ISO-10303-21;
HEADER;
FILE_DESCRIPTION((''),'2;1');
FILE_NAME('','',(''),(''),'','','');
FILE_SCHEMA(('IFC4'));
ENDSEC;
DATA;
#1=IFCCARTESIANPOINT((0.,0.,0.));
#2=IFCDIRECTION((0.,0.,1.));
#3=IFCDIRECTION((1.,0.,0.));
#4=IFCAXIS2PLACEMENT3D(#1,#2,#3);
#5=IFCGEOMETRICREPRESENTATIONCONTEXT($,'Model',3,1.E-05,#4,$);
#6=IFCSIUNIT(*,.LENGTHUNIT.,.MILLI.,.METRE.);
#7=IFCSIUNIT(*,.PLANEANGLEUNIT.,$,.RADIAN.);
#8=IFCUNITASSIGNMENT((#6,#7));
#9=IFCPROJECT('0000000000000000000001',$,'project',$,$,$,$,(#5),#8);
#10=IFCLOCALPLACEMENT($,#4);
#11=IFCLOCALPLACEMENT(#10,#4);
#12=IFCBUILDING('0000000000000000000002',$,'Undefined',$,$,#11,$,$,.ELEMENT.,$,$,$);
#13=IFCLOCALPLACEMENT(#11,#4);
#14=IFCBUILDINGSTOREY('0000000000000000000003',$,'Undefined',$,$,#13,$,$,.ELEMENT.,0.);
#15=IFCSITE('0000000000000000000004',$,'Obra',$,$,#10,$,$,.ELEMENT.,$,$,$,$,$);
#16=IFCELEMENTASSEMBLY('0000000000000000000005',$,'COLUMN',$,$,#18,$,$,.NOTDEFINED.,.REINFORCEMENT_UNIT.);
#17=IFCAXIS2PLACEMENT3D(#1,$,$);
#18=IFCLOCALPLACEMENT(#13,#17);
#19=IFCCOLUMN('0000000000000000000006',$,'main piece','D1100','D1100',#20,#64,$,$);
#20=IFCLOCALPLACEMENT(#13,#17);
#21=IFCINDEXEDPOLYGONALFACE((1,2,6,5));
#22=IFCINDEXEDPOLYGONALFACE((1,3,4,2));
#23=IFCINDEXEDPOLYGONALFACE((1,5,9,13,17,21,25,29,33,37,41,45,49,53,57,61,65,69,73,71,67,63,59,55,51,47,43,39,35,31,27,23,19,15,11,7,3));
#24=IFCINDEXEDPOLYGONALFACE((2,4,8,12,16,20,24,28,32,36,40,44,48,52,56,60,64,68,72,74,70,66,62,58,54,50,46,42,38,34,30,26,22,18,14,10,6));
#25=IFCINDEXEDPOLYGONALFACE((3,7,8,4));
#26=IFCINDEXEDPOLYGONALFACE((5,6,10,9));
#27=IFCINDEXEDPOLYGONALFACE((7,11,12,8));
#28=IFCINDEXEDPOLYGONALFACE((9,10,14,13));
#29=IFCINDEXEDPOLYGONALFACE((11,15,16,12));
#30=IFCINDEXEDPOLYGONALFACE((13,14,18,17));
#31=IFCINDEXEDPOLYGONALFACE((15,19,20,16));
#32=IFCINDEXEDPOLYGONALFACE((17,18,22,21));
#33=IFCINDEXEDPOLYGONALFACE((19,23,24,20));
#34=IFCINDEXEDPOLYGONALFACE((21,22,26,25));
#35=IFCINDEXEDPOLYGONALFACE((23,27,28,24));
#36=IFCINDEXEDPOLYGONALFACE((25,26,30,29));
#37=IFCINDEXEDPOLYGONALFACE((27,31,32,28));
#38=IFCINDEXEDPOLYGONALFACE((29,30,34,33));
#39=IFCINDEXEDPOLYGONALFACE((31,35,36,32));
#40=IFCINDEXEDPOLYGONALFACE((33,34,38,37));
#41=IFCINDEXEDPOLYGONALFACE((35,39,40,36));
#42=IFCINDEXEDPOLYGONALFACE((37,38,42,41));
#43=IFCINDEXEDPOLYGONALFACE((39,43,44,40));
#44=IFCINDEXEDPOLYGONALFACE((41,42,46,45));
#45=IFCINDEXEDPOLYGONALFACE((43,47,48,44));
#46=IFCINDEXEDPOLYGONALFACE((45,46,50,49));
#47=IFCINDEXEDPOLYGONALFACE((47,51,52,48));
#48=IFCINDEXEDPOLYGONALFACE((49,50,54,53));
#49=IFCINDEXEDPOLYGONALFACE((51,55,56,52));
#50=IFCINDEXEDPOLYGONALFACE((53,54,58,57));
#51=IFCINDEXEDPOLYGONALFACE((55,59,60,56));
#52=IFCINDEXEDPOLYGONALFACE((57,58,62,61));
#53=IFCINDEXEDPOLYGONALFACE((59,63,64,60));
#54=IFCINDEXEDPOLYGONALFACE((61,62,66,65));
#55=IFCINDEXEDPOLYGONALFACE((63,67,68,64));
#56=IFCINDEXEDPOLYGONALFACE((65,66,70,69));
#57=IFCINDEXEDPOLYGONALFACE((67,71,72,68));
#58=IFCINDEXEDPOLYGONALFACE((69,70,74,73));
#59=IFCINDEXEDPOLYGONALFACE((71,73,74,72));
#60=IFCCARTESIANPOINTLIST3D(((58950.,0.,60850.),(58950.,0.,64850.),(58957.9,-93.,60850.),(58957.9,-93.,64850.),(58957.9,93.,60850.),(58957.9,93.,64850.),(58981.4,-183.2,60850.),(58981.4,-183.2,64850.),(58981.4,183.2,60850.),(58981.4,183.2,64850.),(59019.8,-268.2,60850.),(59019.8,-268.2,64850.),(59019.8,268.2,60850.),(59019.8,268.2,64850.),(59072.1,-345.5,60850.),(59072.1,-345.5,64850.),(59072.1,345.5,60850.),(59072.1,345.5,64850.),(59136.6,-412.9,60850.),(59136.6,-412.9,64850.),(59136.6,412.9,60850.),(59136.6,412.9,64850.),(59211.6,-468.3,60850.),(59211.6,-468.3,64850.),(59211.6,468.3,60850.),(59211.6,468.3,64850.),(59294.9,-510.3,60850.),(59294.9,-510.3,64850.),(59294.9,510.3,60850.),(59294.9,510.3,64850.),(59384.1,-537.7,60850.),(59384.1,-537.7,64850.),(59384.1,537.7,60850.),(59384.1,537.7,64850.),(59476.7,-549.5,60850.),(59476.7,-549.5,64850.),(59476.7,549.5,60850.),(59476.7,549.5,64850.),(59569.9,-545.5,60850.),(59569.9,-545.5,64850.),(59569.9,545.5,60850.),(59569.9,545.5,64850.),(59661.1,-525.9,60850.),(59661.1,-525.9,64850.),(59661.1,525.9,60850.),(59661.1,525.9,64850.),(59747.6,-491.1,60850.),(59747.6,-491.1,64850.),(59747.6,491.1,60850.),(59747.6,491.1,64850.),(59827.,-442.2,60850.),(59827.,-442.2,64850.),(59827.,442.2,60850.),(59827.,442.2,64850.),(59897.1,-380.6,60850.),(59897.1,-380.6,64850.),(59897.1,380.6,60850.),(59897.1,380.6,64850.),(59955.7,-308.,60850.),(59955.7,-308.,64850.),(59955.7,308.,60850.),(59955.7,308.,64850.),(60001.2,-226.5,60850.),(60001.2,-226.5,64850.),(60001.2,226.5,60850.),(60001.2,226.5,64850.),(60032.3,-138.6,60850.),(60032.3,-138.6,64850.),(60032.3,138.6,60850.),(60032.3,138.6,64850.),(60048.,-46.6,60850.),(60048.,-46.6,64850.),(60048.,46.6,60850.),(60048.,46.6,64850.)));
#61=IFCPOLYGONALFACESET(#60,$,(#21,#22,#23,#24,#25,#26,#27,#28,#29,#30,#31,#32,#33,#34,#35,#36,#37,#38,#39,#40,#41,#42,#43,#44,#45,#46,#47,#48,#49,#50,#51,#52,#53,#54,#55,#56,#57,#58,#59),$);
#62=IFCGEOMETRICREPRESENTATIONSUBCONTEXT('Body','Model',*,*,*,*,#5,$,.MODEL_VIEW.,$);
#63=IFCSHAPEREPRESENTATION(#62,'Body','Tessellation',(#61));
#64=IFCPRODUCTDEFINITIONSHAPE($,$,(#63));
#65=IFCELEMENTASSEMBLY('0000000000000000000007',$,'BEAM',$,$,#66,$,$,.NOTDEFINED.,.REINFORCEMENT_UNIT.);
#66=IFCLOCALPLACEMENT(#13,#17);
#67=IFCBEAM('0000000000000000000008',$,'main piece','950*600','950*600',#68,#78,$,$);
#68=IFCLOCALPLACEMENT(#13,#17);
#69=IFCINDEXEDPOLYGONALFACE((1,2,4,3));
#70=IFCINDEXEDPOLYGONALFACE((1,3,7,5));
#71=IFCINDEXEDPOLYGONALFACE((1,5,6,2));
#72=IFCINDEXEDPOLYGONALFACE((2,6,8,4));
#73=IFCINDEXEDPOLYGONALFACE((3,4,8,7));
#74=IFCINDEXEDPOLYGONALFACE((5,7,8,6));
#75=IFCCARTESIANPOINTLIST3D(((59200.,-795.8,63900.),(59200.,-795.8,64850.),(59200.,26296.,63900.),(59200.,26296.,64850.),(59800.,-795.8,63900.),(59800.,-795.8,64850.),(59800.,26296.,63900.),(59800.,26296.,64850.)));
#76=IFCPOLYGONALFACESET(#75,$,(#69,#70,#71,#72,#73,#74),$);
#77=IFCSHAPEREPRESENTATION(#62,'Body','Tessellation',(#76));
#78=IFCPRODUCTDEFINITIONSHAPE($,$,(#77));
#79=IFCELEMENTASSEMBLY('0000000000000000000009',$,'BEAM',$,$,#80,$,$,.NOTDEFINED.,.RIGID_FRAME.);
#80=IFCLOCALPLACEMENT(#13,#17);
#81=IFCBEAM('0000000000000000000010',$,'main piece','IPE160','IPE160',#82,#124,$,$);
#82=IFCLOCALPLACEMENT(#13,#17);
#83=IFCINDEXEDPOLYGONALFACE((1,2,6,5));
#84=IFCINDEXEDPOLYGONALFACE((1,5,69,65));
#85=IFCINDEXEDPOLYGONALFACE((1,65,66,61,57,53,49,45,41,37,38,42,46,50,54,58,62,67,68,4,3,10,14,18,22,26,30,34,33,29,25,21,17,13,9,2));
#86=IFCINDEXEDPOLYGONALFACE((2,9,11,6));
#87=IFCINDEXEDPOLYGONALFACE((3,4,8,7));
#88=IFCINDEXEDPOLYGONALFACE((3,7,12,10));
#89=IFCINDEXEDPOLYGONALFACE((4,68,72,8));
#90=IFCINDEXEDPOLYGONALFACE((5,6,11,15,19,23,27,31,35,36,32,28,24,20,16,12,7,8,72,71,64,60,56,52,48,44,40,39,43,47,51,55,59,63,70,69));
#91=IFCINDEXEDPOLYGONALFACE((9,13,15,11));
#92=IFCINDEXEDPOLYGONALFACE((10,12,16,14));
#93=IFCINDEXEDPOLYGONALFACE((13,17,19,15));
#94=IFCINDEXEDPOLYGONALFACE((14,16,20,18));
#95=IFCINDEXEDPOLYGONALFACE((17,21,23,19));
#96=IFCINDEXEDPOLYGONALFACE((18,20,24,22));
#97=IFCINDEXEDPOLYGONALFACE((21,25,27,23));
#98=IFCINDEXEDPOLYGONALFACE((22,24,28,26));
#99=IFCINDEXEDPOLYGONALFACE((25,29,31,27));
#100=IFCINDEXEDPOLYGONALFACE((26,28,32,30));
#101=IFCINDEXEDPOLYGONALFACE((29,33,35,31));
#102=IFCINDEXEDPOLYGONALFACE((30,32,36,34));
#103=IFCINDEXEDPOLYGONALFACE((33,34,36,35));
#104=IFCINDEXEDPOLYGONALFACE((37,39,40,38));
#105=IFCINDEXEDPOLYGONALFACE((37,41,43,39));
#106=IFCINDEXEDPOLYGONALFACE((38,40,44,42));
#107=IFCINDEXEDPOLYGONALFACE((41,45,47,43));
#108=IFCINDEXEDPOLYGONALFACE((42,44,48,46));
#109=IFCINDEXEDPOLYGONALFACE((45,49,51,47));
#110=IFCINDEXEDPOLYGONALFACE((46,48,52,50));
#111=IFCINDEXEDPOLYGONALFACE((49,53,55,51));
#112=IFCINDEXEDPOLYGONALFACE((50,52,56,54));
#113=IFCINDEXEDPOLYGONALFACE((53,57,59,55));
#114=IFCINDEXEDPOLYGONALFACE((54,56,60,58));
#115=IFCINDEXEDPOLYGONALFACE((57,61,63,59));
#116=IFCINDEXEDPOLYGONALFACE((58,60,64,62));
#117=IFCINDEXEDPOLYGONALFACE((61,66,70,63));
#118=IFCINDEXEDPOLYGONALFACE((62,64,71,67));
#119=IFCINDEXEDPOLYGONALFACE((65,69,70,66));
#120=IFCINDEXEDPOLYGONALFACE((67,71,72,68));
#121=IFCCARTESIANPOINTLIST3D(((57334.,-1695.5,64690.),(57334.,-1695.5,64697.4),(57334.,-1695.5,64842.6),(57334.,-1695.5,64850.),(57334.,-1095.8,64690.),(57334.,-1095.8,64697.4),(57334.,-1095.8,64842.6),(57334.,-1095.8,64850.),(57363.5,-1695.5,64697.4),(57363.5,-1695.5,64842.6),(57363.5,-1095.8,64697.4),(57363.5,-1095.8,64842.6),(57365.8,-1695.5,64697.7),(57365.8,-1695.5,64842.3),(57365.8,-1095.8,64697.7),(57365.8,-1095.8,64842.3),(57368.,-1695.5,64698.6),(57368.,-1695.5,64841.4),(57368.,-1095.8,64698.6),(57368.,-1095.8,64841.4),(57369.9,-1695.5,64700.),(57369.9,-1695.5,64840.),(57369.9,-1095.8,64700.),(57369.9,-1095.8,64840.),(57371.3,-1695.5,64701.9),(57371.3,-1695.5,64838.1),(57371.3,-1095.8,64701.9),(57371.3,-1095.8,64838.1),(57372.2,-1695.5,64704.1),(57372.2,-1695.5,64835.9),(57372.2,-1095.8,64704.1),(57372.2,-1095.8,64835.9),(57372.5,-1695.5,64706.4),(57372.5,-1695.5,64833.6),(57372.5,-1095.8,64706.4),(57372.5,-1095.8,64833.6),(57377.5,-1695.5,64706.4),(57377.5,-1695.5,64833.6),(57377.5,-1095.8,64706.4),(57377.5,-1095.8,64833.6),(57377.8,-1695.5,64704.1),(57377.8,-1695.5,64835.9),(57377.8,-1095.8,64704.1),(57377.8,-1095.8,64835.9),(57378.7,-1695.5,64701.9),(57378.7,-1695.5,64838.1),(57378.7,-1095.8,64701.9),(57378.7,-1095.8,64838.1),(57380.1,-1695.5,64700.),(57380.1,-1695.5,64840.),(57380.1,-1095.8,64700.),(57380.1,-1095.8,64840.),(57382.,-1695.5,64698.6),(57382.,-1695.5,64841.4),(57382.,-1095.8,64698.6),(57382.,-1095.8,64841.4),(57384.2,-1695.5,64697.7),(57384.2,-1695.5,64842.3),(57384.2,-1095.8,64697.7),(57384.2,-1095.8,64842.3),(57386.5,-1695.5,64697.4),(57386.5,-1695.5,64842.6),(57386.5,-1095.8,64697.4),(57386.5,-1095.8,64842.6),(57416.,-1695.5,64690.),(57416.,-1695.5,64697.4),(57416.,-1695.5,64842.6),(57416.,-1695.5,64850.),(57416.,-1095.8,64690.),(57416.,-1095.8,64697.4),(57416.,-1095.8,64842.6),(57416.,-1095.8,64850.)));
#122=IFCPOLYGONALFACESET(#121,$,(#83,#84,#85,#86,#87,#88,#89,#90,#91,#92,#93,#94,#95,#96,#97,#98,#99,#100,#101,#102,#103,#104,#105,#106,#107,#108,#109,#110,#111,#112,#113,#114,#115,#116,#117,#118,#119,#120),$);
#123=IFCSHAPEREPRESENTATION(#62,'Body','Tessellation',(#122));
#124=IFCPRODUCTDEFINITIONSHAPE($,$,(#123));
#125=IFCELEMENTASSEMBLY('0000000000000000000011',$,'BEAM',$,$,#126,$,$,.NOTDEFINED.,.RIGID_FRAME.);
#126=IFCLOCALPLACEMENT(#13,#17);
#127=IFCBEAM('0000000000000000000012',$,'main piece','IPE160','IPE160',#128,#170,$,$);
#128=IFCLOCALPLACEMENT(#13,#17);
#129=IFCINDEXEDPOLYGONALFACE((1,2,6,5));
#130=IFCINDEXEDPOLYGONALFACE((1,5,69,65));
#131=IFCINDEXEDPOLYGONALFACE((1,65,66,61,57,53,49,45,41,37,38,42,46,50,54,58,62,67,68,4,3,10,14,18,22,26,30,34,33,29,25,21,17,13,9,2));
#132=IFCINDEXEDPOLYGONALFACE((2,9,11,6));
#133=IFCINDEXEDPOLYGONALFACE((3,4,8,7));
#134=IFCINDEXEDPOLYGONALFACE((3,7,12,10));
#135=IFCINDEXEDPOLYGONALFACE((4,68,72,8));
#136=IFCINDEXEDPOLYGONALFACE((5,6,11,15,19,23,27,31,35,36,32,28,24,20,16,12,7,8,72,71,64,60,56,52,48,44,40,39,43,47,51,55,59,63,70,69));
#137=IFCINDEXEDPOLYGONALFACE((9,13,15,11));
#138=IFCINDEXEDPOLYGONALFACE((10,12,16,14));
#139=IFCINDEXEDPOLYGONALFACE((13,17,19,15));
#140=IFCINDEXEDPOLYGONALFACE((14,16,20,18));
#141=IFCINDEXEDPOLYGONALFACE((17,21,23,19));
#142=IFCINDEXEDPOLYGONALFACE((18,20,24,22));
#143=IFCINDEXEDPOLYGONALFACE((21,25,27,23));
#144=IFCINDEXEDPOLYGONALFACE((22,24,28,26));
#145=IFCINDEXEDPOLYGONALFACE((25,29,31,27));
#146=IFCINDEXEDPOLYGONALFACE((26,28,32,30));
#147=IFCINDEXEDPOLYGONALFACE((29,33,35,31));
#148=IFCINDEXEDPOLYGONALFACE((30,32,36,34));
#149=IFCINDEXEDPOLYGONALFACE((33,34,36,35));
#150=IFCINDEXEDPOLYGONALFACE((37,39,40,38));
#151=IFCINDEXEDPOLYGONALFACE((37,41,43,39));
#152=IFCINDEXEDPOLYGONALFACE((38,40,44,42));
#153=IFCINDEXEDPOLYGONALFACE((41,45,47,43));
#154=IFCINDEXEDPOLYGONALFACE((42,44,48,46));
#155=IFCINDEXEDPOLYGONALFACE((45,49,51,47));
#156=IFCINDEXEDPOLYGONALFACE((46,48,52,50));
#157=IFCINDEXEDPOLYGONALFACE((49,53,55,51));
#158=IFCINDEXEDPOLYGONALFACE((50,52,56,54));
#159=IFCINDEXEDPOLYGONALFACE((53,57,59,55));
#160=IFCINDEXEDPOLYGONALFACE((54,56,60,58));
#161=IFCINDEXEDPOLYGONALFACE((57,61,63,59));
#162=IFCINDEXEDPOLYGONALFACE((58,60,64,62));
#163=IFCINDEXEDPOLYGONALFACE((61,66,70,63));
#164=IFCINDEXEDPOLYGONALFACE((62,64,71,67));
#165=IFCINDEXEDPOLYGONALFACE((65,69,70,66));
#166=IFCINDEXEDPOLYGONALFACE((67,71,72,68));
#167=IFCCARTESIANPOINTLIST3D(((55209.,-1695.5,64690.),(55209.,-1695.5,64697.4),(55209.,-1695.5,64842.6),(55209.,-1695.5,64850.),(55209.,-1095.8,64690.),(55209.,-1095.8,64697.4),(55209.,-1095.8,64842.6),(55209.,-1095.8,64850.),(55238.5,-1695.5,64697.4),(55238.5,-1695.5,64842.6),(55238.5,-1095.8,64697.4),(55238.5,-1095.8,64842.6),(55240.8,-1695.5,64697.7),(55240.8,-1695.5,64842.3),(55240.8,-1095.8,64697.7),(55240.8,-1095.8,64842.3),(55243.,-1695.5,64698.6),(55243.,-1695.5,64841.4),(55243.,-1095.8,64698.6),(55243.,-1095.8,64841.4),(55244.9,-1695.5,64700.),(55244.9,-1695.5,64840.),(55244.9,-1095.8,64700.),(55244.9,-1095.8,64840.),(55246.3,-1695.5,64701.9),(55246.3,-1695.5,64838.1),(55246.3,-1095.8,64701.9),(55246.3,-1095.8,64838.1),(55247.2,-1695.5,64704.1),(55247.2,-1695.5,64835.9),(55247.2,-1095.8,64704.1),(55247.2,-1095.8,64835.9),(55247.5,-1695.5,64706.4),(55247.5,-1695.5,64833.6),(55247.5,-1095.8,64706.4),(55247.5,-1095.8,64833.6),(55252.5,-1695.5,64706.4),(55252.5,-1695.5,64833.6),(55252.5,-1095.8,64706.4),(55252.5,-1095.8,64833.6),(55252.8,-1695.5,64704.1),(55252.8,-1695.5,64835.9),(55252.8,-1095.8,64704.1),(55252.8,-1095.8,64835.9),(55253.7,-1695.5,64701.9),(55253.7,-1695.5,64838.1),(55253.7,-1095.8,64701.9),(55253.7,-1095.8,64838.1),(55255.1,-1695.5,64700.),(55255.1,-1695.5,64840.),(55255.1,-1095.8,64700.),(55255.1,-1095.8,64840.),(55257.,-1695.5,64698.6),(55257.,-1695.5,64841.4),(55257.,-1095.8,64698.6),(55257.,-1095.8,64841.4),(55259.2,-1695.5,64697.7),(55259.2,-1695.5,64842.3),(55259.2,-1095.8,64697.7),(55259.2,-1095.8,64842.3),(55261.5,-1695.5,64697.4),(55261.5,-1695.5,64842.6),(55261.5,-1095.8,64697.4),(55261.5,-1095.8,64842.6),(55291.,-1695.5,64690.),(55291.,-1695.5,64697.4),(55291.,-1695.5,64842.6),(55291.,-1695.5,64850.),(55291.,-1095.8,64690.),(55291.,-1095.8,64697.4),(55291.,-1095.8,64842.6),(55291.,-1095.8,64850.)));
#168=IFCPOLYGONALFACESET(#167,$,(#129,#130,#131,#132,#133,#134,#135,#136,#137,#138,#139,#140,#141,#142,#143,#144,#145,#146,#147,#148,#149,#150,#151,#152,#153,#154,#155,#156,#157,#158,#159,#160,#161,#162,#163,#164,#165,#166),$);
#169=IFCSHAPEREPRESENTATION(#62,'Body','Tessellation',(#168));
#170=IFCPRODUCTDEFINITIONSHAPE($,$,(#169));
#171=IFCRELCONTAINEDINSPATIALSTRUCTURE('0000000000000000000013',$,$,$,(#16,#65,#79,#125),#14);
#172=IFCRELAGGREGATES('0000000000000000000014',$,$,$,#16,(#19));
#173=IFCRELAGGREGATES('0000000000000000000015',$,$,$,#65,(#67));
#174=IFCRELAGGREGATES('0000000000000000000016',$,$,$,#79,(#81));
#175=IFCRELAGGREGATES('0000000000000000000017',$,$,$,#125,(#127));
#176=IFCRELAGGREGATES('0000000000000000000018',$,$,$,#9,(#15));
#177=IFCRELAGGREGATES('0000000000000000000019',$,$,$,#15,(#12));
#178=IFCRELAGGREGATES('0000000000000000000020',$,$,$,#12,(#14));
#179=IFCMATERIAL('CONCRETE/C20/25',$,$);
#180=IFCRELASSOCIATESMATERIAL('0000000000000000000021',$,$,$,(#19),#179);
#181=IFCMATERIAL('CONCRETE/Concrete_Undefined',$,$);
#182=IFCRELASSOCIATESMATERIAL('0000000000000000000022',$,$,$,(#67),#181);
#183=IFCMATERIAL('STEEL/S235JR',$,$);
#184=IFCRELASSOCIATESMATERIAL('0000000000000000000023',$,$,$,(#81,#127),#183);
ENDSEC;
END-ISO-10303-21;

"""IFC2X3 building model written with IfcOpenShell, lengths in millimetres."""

from ifc_helpers import new_model, si_unit, frame, origin_with_axes, origin_2d_with_axis, place, context, subcontext, project, spatial, rectangle, circle, i_section, extrude, material, element, aggregate, save


model = new_model("IFC2X3")

# Units and contexts
model_context = context("Model", 3, precision=1e-05, world=origin_with_axes())
body_context = subcontext(model_context, "Body", "Model", "MODEL_VIEW")
ifc_project = project(units=[si_unit("LENGTHUNIT", "METRE", prefix="MILLI"), si_unit("PLANEANGLEUNIT", "RADIAN")], contexts=[model_context])

# Site, building, storey
site_placement = place(None, origin_with_axes())
site = spatial("IfcSite", under=ifc_project, at=site_placement, Name="Obra", CompositionType="ELEMENT")
building_placement = place(site_placement, origin_with_axes())
building = spatial("IfcBuilding", under=site, at=building_placement, Name="Undefined", CompositionType="ELEMENT")
storey_placement = place(building_placement, origin_with_axes())
storey = spatial("IfcBuildingStorey", under=building, at=storey_placement, Name="Undefined", CompositionType="ELEMENT", Elevation=0.0)

# Element assembly, column
assembly_1_placement = place(storey_placement, origin_with_axes())
assembly_1 = element("IfcElementAssembly", 1, at=assembly_1_placement, inside=storey, Name="COLUMN", AssemblyPlace="NOTDEFINED", PredefinedType="REINFORCEMENT_UNIT")
ifc_material_1 = material(Name="CONCRETE/C20/25")
column_placement = place(assembly_1_placement, frame((59500.0, 0.0, 60850.0), z_axis=(0.0, 0.0, 1.0), x_axis=(0.0, 1.0, 0.0)))
column = element("IfcColumn", 2, at=column_placement, material=ifc_material_1, Name="main piece", Description="D1100", ObjectType="D1100", context=body_context, shape_type="SweptSolid", body=[
    extrude(circle(Radius=550.0, at=origin_2d_with_axis()), frame((0.0, 0.0, 4000.0), z_axis=(0.0, 0.0, -1.0), x_axis=(0.0, 1.0, 0.0)), (0.0, 0.0, 1.0), 4000.0),
])
aggregate(assembly_1, [column])

# Element assemblies, beams
assembly_2_placement = place(storey_placement, origin_with_axes())
assembly_2 = element("IfcElementAssembly", 3, at=assembly_2_placement, inside=storey, Name="BEAM", AssemblyPlace="NOTDEFINED", PredefinedType="REINFORCEMENT_UNIT")
ifc_material_2 = material(Name="CONCRETE/Concrete_Undefined")
beam_1_placement = place(assembly_2_placement, frame((59500.0, -795.8, 64375.0), z_axis=(0.0, 0.0, 1.0), x_axis=(0.0, 1.0, 0.0)))
beam_1 = element("IfcBeam", 4, at=beam_1_placement, material=ifc_material_2, Name="main piece", Description="950*600", ObjectType="950*600", context=body_context, shape_type="SweptSolid", body=[
    extrude(rectangle(XDim=600.0, YDim=950.0, at=origin_2d_with_axis()), frame((27091.8, 0.0, 0.0), z_axis=(-1.0, 0.0, 0.0), x_axis=(0.0, -1.0, 0.0)), (0.0, 0.0, 1.0), 27091.8),
])
aggregate(assembly_2, [beam_1])
assembly_3_placement = place(storey_placement, origin_with_axes())
assembly_3 = element("IfcElementAssembly", 5, at=assembly_3_placement, inside=storey, Name="BEAM", AssemblyPlace="NOTDEFINED", PredefinedType="RIGID_FRAME")
ifc_material_3 = material(Name="STEEL/S235JR")
beam_2_placement = place(assembly_3_placement, frame((57375.0, -1095.8, 64770.0), z_axis=(0.0, 0.0, 1.0), x_axis=(0.0, -1.0, 0.0)))
beam_2 = element("IfcBeam", 6, at=beam_2_placement, material=ifc_material_3, Name="main piece", Description="IPE160", ObjectType="IPE160", context=body_context, shape_type="SweptSolid", body=[
    extrude(i_section(OverallWidth=82.0, OverallDepth=160.0, WebThickness=5.0, FlangeThickness=7.4, FilletRadius=9.0, at=origin_2d_with_axis()), frame((599.7, 0.0, 0.0), z_axis=(-1.0, 0.0, 0.0), x_axis=(0.0, -1.0, 0.0)), (0.0, 0.0, 1.0), 599.7),
])
aggregate(assembly_3, [beam_2])
assembly_4_placement = place(storey_placement, origin_with_axes())
assembly_4 = element("IfcElementAssembly", 7, at=assembly_4_placement, inside=storey, Name="BEAM", AssemblyPlace="NOTDEFINED", PredefinedType="RIGID_FRAME")
beam_3_placement = place(assembly_4_placement, frame((55250.0, -1095.8, 64770.0), z_axis=(0.0, 0.0, 1.0), x_axis=(0.0, -1.0, 0.0)))
beam_3 = element("IfcBeam", 8, at=beam_3_placement, material=ifc_material_3, Name="main piece", Description="IPE160", ObjectType="IPE160", context=body_context, shape_type="SweptSolid", body=[
    extrude(i_section(OverallWidth=82.0, OverallDepth=160.0, WebThickness=5.0, FlangeThickness=7.4, FilletRadius=9.0, at=origin_2d_with_axis()), frame((599.7, 0.0, 0.0), z_axis=(-1.0, 0.0, 0.0), x_axis=(0.0, -1.0, 0.0)), (0.0, 0.0, 1.0), 599.7),
])
aggregate(assembly_4, [beam_3])

save(model, "model.ifc")
